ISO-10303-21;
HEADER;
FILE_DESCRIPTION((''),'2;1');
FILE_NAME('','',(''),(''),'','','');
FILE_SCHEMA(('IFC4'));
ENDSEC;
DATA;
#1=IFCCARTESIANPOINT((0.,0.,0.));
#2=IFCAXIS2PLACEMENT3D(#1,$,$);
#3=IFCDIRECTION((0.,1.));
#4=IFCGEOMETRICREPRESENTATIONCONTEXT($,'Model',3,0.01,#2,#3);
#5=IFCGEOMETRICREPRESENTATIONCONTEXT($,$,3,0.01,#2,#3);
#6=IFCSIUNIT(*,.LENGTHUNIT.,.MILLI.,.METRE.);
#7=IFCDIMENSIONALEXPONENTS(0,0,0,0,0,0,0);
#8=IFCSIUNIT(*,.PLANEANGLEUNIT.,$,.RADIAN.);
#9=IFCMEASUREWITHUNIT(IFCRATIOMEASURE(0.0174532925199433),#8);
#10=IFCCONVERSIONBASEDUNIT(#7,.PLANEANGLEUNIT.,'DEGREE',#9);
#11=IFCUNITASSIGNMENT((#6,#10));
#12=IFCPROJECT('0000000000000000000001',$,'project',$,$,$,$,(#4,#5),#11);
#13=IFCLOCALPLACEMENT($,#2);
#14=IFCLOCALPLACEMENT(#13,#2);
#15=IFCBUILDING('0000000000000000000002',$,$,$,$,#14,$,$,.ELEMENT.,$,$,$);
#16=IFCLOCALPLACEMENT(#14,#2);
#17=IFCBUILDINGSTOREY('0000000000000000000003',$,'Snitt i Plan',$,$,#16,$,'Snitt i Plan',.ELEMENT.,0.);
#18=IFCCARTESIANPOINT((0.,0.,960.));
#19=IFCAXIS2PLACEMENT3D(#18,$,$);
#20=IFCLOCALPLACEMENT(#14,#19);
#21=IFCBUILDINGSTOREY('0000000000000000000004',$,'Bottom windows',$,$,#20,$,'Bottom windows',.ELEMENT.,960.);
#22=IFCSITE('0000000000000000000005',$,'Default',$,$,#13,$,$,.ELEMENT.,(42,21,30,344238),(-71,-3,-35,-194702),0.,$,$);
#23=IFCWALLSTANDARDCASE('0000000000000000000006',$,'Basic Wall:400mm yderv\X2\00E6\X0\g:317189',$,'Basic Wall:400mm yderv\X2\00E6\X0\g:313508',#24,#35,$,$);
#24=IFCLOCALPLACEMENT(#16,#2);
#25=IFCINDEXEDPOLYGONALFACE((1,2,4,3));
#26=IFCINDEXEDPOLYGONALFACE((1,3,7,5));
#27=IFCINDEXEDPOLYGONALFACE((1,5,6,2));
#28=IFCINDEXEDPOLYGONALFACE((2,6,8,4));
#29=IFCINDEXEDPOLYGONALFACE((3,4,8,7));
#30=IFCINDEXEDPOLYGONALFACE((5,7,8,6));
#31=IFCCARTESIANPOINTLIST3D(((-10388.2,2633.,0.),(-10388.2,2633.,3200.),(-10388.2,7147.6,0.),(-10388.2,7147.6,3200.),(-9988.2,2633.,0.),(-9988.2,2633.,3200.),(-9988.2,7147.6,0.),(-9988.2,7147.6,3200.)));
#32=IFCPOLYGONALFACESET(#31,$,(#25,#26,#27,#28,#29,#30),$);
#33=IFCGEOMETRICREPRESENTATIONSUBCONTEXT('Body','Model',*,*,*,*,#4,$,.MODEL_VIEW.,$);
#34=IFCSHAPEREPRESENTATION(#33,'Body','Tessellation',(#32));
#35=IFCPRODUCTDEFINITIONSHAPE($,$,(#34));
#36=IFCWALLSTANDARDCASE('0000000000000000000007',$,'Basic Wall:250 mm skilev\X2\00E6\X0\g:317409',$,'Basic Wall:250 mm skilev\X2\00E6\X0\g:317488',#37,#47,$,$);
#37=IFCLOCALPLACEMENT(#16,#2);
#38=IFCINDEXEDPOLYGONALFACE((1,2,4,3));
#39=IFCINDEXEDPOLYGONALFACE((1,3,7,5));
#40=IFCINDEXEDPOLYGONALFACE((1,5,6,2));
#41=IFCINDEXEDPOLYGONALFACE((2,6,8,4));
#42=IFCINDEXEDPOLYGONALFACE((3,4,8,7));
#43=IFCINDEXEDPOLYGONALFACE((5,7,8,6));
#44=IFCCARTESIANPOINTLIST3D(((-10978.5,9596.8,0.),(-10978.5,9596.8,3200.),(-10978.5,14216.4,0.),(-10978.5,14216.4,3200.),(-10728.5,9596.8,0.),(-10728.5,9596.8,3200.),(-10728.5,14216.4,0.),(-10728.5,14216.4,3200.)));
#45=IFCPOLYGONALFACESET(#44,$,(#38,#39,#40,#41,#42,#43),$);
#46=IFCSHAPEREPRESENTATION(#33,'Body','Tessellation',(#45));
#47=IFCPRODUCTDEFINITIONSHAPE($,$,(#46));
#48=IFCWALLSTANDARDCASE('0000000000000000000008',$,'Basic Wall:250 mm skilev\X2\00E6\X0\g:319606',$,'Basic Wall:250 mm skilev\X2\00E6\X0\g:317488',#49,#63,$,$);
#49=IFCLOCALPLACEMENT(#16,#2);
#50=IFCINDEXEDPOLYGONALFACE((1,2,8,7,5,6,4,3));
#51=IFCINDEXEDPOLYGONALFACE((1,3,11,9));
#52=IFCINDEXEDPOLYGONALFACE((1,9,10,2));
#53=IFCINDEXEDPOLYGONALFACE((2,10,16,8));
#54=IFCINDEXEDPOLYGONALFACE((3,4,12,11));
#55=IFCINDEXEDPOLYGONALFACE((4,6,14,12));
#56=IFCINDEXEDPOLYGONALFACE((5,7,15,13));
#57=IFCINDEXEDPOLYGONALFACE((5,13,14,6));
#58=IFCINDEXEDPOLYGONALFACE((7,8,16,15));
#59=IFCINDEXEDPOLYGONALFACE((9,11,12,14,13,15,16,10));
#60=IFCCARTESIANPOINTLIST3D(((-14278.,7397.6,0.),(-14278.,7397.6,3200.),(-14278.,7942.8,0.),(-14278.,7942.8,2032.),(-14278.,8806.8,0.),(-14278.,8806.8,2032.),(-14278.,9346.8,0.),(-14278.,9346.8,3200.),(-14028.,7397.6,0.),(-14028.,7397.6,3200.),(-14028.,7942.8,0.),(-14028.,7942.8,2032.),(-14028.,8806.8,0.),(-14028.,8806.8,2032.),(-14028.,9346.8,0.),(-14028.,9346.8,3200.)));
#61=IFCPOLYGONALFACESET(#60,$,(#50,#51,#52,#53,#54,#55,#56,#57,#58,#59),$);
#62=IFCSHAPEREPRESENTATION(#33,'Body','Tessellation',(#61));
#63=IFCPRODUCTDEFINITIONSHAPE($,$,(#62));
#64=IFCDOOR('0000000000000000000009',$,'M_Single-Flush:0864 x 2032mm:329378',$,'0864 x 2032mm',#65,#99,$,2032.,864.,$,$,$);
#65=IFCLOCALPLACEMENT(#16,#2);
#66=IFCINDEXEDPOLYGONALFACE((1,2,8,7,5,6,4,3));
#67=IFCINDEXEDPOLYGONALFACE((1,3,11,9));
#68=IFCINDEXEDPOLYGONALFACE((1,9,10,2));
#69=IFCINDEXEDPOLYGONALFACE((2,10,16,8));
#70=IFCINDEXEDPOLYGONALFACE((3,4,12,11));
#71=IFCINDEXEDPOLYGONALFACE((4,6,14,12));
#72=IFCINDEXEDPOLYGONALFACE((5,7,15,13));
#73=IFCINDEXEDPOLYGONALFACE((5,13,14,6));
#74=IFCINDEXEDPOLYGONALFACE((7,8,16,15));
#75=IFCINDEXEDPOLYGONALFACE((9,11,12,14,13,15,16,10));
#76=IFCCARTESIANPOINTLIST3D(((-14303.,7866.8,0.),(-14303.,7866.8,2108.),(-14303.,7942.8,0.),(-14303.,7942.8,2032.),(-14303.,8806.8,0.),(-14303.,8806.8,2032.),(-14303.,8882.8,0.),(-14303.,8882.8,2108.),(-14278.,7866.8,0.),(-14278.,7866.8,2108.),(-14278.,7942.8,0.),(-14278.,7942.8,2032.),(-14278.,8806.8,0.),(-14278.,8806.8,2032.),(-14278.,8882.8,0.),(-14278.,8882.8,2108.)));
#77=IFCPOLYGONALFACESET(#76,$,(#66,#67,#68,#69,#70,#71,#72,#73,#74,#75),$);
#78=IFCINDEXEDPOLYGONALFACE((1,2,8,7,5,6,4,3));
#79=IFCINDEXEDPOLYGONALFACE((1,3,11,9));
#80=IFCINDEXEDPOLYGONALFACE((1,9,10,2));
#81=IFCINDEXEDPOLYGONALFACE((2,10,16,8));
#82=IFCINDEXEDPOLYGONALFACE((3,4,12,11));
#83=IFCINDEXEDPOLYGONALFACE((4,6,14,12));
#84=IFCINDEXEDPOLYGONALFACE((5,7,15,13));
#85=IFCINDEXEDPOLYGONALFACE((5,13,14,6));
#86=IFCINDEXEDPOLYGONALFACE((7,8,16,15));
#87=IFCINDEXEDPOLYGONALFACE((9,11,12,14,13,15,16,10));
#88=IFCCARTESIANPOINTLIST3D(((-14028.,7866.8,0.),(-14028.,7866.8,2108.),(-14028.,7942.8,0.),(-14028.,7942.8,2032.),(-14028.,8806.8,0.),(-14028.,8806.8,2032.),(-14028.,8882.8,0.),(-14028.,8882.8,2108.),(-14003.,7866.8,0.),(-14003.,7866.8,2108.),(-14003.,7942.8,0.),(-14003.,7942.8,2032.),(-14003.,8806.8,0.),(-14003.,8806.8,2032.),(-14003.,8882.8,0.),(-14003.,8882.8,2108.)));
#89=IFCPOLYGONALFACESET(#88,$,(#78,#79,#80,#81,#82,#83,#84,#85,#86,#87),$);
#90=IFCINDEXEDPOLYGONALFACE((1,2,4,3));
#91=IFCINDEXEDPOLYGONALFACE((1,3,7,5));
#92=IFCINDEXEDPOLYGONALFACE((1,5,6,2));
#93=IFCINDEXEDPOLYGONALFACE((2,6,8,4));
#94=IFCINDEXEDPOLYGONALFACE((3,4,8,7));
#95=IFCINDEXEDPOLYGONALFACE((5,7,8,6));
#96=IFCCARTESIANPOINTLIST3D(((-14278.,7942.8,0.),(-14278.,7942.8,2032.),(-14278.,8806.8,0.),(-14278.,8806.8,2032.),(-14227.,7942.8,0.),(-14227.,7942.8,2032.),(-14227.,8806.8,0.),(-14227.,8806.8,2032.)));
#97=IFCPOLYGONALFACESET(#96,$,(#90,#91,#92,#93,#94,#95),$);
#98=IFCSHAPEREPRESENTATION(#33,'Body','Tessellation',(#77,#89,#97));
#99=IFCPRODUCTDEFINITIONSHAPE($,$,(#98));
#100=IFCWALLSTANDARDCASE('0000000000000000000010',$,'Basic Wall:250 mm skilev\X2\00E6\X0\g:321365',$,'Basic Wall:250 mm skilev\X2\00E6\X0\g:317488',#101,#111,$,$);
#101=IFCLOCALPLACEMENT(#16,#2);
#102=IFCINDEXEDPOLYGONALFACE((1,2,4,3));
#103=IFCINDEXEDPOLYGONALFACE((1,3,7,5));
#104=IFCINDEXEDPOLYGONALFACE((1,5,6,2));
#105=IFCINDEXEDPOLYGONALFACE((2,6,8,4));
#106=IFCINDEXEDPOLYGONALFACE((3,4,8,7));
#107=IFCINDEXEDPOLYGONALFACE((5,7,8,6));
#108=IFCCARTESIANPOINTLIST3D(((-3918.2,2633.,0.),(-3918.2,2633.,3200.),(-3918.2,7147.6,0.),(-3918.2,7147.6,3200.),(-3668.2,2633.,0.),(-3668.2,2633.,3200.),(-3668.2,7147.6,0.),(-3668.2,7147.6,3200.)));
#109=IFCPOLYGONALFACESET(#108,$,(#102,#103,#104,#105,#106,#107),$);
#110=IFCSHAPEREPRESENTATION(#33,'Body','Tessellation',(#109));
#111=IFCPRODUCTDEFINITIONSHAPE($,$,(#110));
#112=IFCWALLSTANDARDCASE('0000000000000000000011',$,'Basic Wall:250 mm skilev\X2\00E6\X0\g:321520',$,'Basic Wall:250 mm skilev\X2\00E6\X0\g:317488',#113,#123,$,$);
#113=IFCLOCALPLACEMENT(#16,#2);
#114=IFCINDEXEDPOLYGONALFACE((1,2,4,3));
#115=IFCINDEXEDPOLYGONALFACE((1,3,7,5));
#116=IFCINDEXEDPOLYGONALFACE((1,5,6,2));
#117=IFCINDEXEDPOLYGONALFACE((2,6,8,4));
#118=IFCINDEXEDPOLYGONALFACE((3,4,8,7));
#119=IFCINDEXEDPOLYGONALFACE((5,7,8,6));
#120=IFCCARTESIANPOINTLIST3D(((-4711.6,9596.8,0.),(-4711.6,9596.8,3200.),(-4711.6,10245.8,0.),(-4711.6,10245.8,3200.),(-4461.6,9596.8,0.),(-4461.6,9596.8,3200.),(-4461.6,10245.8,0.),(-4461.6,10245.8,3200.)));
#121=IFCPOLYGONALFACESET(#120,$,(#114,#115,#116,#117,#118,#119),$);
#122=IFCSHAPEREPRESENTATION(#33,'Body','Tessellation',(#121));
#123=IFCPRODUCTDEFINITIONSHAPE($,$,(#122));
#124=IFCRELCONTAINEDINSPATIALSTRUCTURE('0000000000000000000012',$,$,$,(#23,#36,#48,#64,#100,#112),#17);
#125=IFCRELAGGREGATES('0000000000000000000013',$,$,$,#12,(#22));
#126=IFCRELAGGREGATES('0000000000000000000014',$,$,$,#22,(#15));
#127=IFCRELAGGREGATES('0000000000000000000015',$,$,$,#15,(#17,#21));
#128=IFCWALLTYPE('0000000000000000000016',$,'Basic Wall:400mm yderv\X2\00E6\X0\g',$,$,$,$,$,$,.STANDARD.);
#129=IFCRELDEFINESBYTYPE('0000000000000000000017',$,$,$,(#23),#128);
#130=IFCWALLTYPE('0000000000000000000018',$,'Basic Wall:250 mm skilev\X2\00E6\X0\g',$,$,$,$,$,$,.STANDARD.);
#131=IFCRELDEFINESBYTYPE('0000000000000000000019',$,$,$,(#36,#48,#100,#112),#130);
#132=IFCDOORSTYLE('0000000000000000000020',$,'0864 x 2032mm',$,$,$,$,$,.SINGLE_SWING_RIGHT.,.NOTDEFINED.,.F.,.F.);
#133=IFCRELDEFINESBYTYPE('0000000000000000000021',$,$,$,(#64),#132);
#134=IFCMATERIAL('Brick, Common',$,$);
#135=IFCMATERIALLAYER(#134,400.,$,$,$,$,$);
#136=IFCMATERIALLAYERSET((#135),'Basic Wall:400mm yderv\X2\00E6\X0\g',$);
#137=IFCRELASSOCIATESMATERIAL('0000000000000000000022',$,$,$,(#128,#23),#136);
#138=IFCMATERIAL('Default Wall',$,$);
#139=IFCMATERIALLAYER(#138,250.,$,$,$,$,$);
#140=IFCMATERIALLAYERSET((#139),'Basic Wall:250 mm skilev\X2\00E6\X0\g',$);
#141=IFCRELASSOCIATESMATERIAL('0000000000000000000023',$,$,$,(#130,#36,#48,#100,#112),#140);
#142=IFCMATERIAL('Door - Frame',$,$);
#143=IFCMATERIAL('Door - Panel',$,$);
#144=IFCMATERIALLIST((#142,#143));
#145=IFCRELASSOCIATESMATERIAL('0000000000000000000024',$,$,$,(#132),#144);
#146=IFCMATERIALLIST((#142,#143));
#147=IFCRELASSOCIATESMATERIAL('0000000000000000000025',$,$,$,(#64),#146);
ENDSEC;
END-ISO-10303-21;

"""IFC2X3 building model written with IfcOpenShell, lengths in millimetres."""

from ifc_helpers import new_model, entity, si_unit, converted_unit, direction, frame, frame_2d, origin, place, context, subcontext, project, spatial, polyline, rectangle, outline, extrude, source, transform, mapped, material, material_list, layer, layer_set, layer_usage, type_object, type_shapes, element, fill, save


model = new_model("IFC2X3")

# Units and contexts
model_context = context("Model", 3, precision=0.01, world=origin(), true_north=direction((0.0, 1.0)))
context_of_model = context(None, 3, precision=0.01, world=origin(), true_north=direction((0.0, 1.0)))
body_context = subcontext(model_context, "Body", "Model", "MODEL_VIEW")
ifc_project = project(units=[si_unit("LENGTHUNIT", "METRE", prefix="MILLI"), converted_unit("PLANEANGLEUNIT", "DEGREE", entity("IfcRatioMeasure", 0.0174532925199433), si_unit("PLANEANGLEUNIT", "RADIAN"), dimensions=[0, 0, 0, 0, 0, 0, 0])], contexts=[model_context, context_of_model])

# Site, building, storey
site_placement = place(None, origin())
site = spatial("IfcSite", under=ifc_project, at=site_placement, Name="Default", CompositionType="ELEMENT", RefLatitude=(42, 21, 30, 344238), RefLongitude=(-71, -3, -35, -194702), RefElevation=0.0)
building_placement = place(site_placement, origin())
building = spatial("IfcBuilding", under=site, at=building_placement, CompositionType="ELEMENT")
storey_1_placement = place(building_placement, origin())
storey_1 = spatial("IfcBuildingStorey", under=building, at=storey_1_placement, Name="Snitt i Plan", LongName="Snitt i Plan", CompositionType="ELEMENT", Elevation=0.0)

# Shared definitions
ifc_material_1 = material(Name="Brick, Common")
ifc_layer_1 = layer(ifc_material_1, 400.0)
ifc_layer_set_1 = layer_set([ifc_layer_1], Name="Basic Wall:400mm ydervæg")
wall_type_1 = type_object("IfcWallType", Name="Basic Wall:400mm ydervæg", PredefinedType="STANDARD", material=ifc_layer_set_1)

# Shared definitions
storey_2_placement = place(building_placement, frame((0.0, 0.0, 960.0)))
storey_2 = spatial("IfcBuildingStorey", under=building, at=storey_2_placement, Name="Bottom windows", LongName="Bottom windows", CompositionType="ELEMENT", Elevation=960.0)

# Wall
ifc_layer_usage_1 = layer_usage(ifc_layer_set_1, "AXIS2", "NEGATIVE", 200.0)
wall_1_placement = place(storey_1_placement, frame((-10188.2, 2633.0, 0.0), z_axis=(0.0, 0.0, 1.0), x_axis=(0.0, 1.0, 0.0)))
element("IfcWallStandardCase", 1, at=wall_1_placement, inside=storey_1, type_object=wall_type_1, material=ifc_layer_usage_1, Name="Basic Wall:400mm ydervæg:317189", ObjectType="Basic Wall:400mm ydervæg:313508", context=body_context, shape_type="SweptSolid", body=[
    extrude(rectangle(XDim=4514.6, YDim=400.0, at=frame_2d((2257.3, 0.0), x_axis=(-1.0, 0.0))), origin(), (0.0, 0.0, 1.0), 3200.0),
])

# Shared definitions
ifc_material_2 = material(Name="Default Wall")
ifc_layer_2 = layer(ifc_material_2, 250.0)
ifc_layer_set_2 = layer_set([ifc_layer_2], Name="Basic Wall:250 mm skilevæg")
wall_type_2 = type_object("IfcWallType", Name="Basic Wall:250 mm skilevæg", PredefinedType="STANDARD", material=ifc_layer_set_2)
ifc_material_3 = material(Name="Door - Frame")
ifc_material_4 = material(Name="Door - Panel")
ifc_material_list_1 = material_list([ifc_material_3, ifc_material_4])
door_style_1 = type_object("IfcDoorStyle", Name="0864 x 2032mm", ConstructionType="NOTDEFINED", OperationType="SINGLE_SWING_RIGHT", ParameterTakesPrecedence=False, Sizeable=False, material=ifc_material_list_1)
shared_shape_1 = source(origin(), body_context, "Body", "SweptSolid", [
    extrude(outline(polyline([(-508.0, -1073.0), (508.0, -1073.0), (508.0, 1035.0), (432.0, 1035.0), (432.0, -997.0), (-432.0, -997.0), (-432.0, 1035.0), (-508.0, 1035.0), (-508.0, -1073.0)])), frame((432.0, 250.0, 1035.0), z_axis=(0.0, 1.0, 0.0), x_axis=(1.0, 0.0, 0.0)), (0.0, 0.0, 1.0), 25.0),
    extrude(outline(polyline([(-1073.0, -508.0), (1035.0, -508.0), (1035.0, -432.0), (-997.0, -432.0), (-997.0, 432.0), (1035.0, 432.0), (1035.0, 508.0), (-1073.0, 508.0), (-1073.0, -508.0)])), frame((432.0, -25.0, 1035.0), z_axis=(0.0, 1.0, 0.0), x_axis=(0.0, 0.0, -1.0)), (0.0, 0.0, 1.0), 25.0),
    extrude(rectangle(XDim=51.0, YDim=864.0, at=frame_2d((0.0, 0.0), x_axis=(1.0, 0.0))), frame((432.0, 224.5, 0.0), z_axis=(0.0, 0.0, 1.0), x_axis=(0.0, 1.0, 0.0)), (0.0, 0.0, 1.0), 2032.0),
])
type_shapes(door_style_1, [shared_shape_1])

# Wall
ifc_layer_usage_2 = layer_usage(ifc_layer_set_2, "AXIS2", "NEGATIVE", 125.0)
wall_2_placement = place(storey_1_placement, frame((-10853.5, 9596.8, 0.0), z_axis=(0.0, 0.0, 1.0), x_axis=(0.0, 1.0, 0.0)))
element("IfcWallStandardCase", 2, at=wall_2_placement, inside=storey_1, type_object=wall_type_2, material=ifc_layer_usage_2, Name="Basic Wall:250 mm skilevæg:317409", ObjectType="Basic Wall:250 mm skilevæg:317488", context=body_context, shape_type="SweptSolid", body=[
    extrude(rectangle(XDim=4619.6, YDim=250.0, at=frame_2d((2309.8, 0.0), x_axis=(-1.0, 0.0))), origin(), (0.0, 0.0, 1.0), 3200.0),
])

# Wall, opening, door
ifc_layer_usage_3 = layer_usage(ifc_layer_set_2, "AXIS2", "NEGATIVE", 125.0)
wall_3_placement = place(storey_1_placement, frame((-14153.0, 7397.6, 0.0), z_axis=(0.0, 0.0, 1.0), x_axis=(0.0, 1.0, 0.0)))
wall_3 = element("IfcWallStandardCase", 3, at=wall_3_placement, inside=storey_1, type_object=wall_type_2, material=ifc_layer_usage_3, Name="Basic Wall:250 mm skilevæg:319606", ObjectType="Basic Wall:250 mm skilevæg:317488", context=body_context, shape_type="SweptSolid", body=[
    extrude(rectangle(XDim=1949.2, YDim=250.0, at=frame_2d((974.6, 0.0), x_axis=(-1.0, 0.0))), origin(), (0.0, 0.0, 1.0), 3200.0),
])
opening_1_placement = place(wall_3_placement, frame((545.2, -125.0, 0.0)))
opening_1 = element("IfcOpeningElement", 4, at=opening_1_placement, cuts=wall_3, ObjectType="Opening", context=body_context, shape_type="SweptSolid", body=[
    extrude(rectangle(XDim=864.0, YDim=2032.0, at=frame_2d((1016.0, 432.0), x_axis=(0.0, 1.0))), frame((0.0, 0.0, 0.0), z_axis=(0.0, 1.0, 0.0), x_axis=(0.0, 0.0, 1.0)), (0.0, 0.0, 1.0), 250.0),
])
ifc_material_list_2 = material_list([ifc_material_3, ifc_material_4])
door_1_placement = place(opening_1_placement, origin())
door_1 = element("IfcDoor", 5, at=door_1_placement, inside=storey_1, type_object=door_style_1, material=ifc_material_list_2, Name="M_Single-Flush:0864 x 2032mm:329378", ObjectType="0864 x 2032mm", OverallHeight=2032.0, OverallWidth=864.0, context=body_context, shape_type="MappedRepresentation", body=[
    mapped(shared_shape_1, transform((0.0, 0.0, 0.0), scale=1.0)),
])
fill(opening_1, door_1)

# Walls
ifc_layer_usage_4 = layer_usage(ifc_layer_set_2, "AXIS2", "NEGATIVE", 125.0)
wall_4_placement = place(storey_1_placement, frame((-3793.2, 7147.6, 0.0), z_axis=(0.0, 0.0, 1.0), x_axis=(0.0, -1.0, 0.0)))
element("IfcWallStandardCase", 6, at=wall_4_placement, inside=storey_1, type_object=wall_type_2, material=ifc_layer_usage_4, Name="Basic Wall:250 mm skilevæg:321365", ObjectType="Basic Wall:250 mm skilevæg:317488", context=body_context, shape_type="SweptSolid", body=[
    extrude(rectangle(XDim=4514.6, YDim=250.0, at=frame_2d((2257.3, 0.0), x_axis=(-1.0, 0.0))), origin(), (0.0, 0.0, 1.0), 3200.0),
])
ifc_layer_usage_5 = layer_usage(ifc_layer_set_2, "AXIS2", "NEGATIVE", 125.0)
wall_5_placement = place(storey_1_placement, frame((-4586.6, 9596.8, 0.0), z_axis=(0.0, 0.0, 1.0), x_axis=(0.0, 1.0, 0.0)))
element("IfcWallStandardCase", 7, at=wall_5_placement, inside=storey_1, type_object=wall_type_2, material=ifc_layer_usage_5, Name="Basic Wall:250 mm skilevæg:321520", ObjectType="Basic Wall:250 mm skilevæg:317488", context=body_context, shape_type="SweptSolid", body=[
    extrude(rectangle(XDim=649.0, YDim=250.0, at=frame_2d((324.5, 0.0), x_axis=(-1.0, 0.0))), origin(), (0.0, 0.0, 1.0), 3200.0),
])

save(model, "model.ifc")
